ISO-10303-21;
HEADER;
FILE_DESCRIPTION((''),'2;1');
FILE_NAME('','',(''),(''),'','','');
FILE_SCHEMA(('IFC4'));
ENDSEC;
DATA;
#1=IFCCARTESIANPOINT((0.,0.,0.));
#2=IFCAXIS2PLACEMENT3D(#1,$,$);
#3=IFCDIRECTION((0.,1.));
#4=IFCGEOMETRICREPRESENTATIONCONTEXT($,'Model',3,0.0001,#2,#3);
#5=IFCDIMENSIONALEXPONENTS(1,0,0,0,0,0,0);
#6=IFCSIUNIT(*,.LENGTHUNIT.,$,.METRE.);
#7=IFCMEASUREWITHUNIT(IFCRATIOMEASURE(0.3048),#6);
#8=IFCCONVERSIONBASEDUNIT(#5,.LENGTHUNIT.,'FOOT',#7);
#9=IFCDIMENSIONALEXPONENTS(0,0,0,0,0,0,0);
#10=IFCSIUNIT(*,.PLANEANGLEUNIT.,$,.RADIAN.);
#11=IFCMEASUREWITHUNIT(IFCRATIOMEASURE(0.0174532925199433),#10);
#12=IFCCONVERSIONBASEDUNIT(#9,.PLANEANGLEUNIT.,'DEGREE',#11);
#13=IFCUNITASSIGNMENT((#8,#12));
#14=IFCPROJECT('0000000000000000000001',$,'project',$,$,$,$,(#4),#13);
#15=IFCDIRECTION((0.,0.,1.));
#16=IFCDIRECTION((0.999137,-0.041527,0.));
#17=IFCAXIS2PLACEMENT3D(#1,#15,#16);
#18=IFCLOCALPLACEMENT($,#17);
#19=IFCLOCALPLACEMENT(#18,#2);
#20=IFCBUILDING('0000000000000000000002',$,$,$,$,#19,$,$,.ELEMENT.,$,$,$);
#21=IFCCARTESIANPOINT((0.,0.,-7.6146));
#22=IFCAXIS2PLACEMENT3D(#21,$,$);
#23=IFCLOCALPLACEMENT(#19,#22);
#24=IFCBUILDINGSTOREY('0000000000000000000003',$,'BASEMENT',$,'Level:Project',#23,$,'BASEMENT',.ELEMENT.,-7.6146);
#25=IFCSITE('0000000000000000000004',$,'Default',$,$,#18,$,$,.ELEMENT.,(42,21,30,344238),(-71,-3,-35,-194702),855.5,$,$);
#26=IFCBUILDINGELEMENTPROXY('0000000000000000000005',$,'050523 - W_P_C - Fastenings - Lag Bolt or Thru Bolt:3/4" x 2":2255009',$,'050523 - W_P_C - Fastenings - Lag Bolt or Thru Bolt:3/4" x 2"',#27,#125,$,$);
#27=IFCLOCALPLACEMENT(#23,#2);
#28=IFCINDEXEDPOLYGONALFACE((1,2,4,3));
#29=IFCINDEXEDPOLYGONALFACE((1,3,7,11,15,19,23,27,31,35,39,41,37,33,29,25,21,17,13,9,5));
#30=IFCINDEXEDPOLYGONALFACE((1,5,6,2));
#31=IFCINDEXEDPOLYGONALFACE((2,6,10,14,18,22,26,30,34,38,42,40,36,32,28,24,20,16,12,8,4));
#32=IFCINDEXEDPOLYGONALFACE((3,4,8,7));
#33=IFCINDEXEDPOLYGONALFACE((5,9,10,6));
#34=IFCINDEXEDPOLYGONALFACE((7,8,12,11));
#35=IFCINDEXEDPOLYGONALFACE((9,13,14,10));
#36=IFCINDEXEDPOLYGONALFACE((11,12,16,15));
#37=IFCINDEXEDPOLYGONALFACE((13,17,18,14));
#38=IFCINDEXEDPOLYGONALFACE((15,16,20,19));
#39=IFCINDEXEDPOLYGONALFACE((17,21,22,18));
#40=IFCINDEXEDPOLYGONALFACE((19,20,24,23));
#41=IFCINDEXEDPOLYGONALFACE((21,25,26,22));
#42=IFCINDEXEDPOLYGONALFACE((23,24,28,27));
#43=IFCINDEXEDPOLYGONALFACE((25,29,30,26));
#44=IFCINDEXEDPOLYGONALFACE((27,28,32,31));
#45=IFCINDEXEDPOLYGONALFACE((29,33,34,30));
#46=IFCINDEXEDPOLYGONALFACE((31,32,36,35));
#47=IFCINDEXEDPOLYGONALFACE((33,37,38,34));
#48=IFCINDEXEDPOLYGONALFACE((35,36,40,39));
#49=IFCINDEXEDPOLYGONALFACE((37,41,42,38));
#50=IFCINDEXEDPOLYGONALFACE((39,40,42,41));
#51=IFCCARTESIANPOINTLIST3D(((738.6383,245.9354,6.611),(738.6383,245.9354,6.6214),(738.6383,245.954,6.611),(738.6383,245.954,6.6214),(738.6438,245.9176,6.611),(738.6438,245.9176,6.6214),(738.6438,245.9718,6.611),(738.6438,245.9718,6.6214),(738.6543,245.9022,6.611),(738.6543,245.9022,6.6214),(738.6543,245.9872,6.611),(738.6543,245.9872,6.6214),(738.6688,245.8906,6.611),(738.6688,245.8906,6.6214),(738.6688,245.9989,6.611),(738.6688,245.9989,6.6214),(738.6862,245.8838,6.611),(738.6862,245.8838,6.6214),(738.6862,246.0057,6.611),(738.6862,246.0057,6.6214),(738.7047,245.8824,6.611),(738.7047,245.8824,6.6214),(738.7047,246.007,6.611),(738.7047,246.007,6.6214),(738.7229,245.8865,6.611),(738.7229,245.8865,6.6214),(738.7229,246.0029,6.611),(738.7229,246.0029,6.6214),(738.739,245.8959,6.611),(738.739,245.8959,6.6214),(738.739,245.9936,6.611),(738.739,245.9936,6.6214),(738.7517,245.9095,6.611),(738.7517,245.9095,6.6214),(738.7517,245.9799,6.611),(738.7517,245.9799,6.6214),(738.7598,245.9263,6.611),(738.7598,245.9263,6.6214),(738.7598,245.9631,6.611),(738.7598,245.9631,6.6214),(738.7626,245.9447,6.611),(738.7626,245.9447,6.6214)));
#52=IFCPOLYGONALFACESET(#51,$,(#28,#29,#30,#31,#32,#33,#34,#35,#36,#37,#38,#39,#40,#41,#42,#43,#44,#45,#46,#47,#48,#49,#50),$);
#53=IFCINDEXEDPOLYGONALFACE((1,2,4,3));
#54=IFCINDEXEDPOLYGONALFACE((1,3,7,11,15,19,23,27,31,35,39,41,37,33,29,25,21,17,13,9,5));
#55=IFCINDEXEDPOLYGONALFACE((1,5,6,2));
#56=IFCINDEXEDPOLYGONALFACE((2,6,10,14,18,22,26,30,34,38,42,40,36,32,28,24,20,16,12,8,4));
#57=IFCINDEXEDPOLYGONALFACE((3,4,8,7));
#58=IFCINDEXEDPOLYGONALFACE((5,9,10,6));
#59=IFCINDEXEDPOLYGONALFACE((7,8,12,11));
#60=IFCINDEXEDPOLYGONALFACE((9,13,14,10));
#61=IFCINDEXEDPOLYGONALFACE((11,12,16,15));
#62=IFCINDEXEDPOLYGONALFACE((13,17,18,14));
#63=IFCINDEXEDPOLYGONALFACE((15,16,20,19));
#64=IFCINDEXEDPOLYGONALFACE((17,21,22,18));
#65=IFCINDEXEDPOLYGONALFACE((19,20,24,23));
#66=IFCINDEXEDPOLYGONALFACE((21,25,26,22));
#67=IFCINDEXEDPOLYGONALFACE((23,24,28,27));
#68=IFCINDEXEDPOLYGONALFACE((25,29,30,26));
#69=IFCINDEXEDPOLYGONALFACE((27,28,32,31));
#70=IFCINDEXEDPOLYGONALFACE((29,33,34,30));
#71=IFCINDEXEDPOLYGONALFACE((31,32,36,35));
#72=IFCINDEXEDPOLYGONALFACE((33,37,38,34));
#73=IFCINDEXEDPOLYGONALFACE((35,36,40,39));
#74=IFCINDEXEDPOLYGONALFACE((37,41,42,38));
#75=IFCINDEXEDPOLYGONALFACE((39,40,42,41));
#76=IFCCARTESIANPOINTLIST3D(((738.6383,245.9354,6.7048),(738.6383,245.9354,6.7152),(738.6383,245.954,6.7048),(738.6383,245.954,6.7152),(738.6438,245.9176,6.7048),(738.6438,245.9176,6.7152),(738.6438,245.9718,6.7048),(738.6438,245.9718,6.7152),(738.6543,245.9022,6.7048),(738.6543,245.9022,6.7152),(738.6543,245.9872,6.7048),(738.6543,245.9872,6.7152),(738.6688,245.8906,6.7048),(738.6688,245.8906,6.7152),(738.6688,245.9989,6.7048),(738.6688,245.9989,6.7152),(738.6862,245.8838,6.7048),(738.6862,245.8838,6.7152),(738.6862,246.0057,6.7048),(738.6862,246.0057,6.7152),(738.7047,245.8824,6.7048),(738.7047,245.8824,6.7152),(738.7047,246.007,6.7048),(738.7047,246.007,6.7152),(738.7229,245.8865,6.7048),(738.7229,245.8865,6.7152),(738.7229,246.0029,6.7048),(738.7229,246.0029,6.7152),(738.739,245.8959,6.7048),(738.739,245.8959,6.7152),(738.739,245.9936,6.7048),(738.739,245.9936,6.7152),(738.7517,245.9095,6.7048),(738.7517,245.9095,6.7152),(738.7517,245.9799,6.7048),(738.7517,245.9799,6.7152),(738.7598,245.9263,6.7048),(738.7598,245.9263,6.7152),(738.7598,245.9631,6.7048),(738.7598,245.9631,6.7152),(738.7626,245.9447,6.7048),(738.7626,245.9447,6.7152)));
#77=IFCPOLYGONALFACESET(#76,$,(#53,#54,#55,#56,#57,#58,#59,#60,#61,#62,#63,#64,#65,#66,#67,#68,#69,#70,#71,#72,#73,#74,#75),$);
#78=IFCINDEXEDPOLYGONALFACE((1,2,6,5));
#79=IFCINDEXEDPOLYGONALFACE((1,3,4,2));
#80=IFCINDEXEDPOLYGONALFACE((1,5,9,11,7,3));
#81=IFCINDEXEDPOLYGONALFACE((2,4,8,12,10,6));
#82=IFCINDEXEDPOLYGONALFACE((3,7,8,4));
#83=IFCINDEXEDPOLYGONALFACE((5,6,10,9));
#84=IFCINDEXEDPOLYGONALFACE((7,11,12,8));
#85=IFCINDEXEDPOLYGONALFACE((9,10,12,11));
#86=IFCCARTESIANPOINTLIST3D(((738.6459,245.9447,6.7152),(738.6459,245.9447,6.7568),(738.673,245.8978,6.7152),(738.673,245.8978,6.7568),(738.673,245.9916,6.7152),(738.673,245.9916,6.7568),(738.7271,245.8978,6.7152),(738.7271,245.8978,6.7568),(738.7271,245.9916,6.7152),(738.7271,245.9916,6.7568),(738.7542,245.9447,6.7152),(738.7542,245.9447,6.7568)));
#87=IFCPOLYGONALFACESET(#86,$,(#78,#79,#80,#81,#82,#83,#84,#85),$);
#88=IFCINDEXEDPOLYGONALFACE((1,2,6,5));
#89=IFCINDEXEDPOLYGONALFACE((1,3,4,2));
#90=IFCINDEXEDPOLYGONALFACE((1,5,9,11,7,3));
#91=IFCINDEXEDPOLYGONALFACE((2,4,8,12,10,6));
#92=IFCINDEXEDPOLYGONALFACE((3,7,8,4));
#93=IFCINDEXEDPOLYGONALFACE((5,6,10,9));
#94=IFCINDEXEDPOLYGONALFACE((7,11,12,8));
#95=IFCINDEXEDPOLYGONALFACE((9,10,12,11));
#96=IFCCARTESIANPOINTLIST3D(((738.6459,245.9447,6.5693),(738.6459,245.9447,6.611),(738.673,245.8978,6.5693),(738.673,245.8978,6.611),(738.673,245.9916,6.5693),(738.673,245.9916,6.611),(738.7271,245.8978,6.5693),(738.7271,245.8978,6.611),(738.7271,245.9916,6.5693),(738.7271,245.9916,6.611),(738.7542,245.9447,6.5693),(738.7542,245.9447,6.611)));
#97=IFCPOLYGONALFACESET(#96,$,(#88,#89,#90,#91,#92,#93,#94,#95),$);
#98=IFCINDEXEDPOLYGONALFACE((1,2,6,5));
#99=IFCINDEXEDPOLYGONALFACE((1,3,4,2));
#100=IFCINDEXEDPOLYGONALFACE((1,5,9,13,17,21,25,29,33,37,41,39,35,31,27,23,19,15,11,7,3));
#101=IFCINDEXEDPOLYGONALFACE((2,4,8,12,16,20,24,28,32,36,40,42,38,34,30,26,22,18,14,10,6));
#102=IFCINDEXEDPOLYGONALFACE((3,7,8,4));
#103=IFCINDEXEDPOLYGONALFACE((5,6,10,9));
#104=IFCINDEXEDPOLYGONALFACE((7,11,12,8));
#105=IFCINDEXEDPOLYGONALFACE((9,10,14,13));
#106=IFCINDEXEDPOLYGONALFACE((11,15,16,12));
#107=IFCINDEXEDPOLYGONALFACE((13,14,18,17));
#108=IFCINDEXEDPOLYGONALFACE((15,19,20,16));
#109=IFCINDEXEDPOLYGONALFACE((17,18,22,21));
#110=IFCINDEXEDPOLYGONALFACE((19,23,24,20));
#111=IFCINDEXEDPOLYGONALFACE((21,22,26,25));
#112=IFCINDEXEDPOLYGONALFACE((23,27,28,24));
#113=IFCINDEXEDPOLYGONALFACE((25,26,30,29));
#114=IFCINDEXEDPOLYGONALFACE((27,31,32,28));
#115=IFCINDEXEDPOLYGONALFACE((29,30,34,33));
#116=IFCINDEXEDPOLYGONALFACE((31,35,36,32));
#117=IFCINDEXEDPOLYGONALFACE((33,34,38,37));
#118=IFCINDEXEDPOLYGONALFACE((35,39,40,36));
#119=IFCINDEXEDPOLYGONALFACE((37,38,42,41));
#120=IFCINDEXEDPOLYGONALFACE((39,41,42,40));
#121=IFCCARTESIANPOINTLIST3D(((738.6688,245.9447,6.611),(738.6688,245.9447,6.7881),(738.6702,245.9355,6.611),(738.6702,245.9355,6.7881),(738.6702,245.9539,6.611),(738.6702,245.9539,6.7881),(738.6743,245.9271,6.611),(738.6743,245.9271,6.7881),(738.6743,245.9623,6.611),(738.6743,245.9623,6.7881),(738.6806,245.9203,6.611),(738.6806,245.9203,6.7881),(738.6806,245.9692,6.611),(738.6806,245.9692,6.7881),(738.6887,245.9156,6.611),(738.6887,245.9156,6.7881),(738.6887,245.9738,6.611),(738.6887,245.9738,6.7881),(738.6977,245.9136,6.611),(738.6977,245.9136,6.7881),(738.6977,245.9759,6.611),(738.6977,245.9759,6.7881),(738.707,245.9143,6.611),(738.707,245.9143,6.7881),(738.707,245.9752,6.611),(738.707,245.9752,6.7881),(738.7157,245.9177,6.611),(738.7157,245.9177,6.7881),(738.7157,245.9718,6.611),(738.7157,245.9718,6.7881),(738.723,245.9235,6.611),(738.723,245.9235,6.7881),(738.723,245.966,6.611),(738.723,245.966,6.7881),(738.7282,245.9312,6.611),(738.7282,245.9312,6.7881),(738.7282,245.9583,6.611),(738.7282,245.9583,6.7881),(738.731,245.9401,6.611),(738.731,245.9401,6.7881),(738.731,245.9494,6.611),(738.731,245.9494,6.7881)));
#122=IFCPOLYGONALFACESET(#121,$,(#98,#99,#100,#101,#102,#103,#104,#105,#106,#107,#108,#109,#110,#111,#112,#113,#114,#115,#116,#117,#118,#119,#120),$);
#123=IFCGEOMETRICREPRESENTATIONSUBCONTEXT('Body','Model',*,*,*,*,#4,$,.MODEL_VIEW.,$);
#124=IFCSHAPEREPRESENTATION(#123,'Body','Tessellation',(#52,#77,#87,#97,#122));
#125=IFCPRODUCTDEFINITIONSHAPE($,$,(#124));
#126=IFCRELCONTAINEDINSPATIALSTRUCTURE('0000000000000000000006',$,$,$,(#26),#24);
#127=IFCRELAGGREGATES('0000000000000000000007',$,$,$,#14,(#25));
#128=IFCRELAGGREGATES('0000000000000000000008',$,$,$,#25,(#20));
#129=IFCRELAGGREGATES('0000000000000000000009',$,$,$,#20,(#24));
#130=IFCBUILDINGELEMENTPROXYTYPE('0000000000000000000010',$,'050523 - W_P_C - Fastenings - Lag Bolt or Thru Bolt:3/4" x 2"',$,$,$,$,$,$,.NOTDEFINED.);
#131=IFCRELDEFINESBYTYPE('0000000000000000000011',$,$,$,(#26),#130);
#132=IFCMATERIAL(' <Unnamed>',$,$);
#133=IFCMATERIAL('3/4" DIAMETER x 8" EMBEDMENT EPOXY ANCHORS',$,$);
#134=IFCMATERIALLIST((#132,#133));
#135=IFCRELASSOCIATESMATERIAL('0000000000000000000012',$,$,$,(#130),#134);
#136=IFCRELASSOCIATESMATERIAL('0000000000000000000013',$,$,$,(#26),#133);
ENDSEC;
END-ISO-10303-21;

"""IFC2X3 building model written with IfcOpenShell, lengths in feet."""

from ifc_helpers import new_model, entity, si_unit, converted_unit, direction, frame, frame_2d, origin, place, context, subcontext, project, spatial, polyline, circle, outline, extrude, source, transform, mapped, material, material_list, type_object, type_shapes, element, save


model = new_model("IFC2X3")

# Units and contexts
model_context = context("Model", 3, precision=0.0001, world=origin(), true_north=direction((0.0, 1.0)))
body_context = subcontext(model_context, "Body", "Model", "MODEL_VIEW")
ifc_project = project(units=[converted_unit("LENGTHUNIT", "FOOT", entity("IfcRatioMeasure", 0.3048), si_unit("LENGTHUNIT", "METRE"), dimensions=[1, 0, 0, 0, 0, 0, 0]), converted_unit("PLANEANGLEUNIT", "DEGREE", entity("IfcRatioMeasure", 0.0174532925199433), si_unit("PLANEANGLEUNIT", "RADIAN"), dimensions=[0, 0, 0, 0, 0, 0, 0])], contexts=[model_context])

# Site, building, storey
site_placement = place(None, frame((0.0, 0.0, 0.0), z_axis=(0.0, 0.0, 1.0), x_axis=(0.999137, -0.041527, 0.0)))
site = spatial("IfcSite", under=ifc_project, at=site_placement, Name="Default", CompositionType="ELEMENT", RefLatitude=(42, 21, 30, 344238), RefLongitude=(-71, -3, -35, -194702), RefElevation=855.5)
building_placement = place(site_placement, origin())
building = spatial("IfcBuilding", under=site, at=building_placement, CompositionType="ELEMENT")
storey_placement = place(building_placement, frame((0.0, 0.0, -7.6146)))
storey = spatial("IfcBuildingStorey", under=building, at=storey_placement, Name="BASEMENT", ObjectType="Level:Project", LongName="BASEMENT", CompositionType="ELEMENT", Elevation=-7.6146)

# Building element proxy
ifc_material_1 = material(Name=" <Unnamed>")
ifc_material_2 = material(Name="3/4\" DIAMETER x 8\" EMBEDMENT EPOXY ANCHORS")
ifc_material_list_1 = material_list([ifc_material_1, ifc_material_2])
building_element_proxy_type_1 = type_object("IfcBuildingElementProxyType", Name="050523 - W_P_C - Fastenings - Lag Bolt or Thru Bolt:3/4\" x 2\"", PredefinedType="NOTDEFINED", material=ifc_material_list_1)
shared_shape_1 = source(origin(), body_context, "Body", "SweptSolid", [
    extrude(circle(Radius=0.0625, at=frame_2d((0.0, 0.0), x_axis=(1.0, 0.0))), frame((0.0, 0.0, 0.0), z_axis=(0.0, 0.0, 1.0), x_axis=(0.0, -1.0, 0.0)), (0.0, 0.0, 1.0), 0.0104),
    extrude(circle(Radius=0.0625, at=frame_2d((0.0, 0.0), x_axis=(1.0, 0.0))), frame((0.0, 0.0, -0.0938), z_axis=(0.0, 0.0, 1.0), x_axis=(0.0, -1.0, 0.0)), (0.0, 0.0, 1.0), 0.0104),
    extrude(outline(polyline([(-0.0271, -0.0469), (0.0271, -0.0469), (0.0541, 0.0), (0.0271, 0.0469), (-0.0271, 0.0469), (-0.0541, 0.0), (-0.0271, -0.0469)])), frame((0.0, 0.0, -0.1354), z_axis=(0.0, 0.0, 1.0), x_axis=(0.866025, -0.5, 0.0)), (0.0, 0.0, 1.0), 0.0417),
    extrude(outline(polyline([(-0.0271, -0.0469), (0.0271, -0.0469), (0.0541, 0.0), (0.0271, 0.0469), (-0.0271, 0.0469), (-0.0541, 0.0), (-0.0271, -0.0469)])), frame((0.0, 0.0, 0.0104), z_axis=(0.0, 0.0, 1.0), x_axis=(0.0, -1.0, 0.0)), (0.0, 0.0, 1.0), 0.0417),
    extrude(circle(Radius=0.0312, at=frame_2d((0.0, 0.0), x_axis=(1.0, 0.0))), frame((0.0, 0.0, -0.1667), z_axis=(0.0, 0.0, 1.0), x_axis=(0.0, 1.0, 0.0)), (0.0, 0.0, 1.0), 0.1771),
])
type_shapes(building_element_proxy_type_1, [shared_shape_1])
for number, where, z_axis, x_axis, name in (
    (1, (738.7001, 245.9447, 6.6214), (0.0, 0.0, -1.0), (0.0, -1.0, 0.0), "050523 - W_P_C - Fastenings - Lag Bolt or Thru Bolt:3/4\" x 2\":2255009"),
):
    element("IfcBuildingElementProxy", number, at=place(storey_placement, frame(where, z_axis=z_axis, x_axis=x_axis)), inside=storey, type_object=building_element_proxy_type_1, material=ifc_material_2, Name=name, ObjectType="050523 - W_P_C - Fastenings - Lag Bolt or Thru Bolt:3/4\" x 2\"", context=body_context, shape_type="MappedRepresentation", body=[
        mapped(shared_shape_1, transform((0.0, 0.0, 0.0), scale=1.0)),
    ])

save(model, "model.ifc")
